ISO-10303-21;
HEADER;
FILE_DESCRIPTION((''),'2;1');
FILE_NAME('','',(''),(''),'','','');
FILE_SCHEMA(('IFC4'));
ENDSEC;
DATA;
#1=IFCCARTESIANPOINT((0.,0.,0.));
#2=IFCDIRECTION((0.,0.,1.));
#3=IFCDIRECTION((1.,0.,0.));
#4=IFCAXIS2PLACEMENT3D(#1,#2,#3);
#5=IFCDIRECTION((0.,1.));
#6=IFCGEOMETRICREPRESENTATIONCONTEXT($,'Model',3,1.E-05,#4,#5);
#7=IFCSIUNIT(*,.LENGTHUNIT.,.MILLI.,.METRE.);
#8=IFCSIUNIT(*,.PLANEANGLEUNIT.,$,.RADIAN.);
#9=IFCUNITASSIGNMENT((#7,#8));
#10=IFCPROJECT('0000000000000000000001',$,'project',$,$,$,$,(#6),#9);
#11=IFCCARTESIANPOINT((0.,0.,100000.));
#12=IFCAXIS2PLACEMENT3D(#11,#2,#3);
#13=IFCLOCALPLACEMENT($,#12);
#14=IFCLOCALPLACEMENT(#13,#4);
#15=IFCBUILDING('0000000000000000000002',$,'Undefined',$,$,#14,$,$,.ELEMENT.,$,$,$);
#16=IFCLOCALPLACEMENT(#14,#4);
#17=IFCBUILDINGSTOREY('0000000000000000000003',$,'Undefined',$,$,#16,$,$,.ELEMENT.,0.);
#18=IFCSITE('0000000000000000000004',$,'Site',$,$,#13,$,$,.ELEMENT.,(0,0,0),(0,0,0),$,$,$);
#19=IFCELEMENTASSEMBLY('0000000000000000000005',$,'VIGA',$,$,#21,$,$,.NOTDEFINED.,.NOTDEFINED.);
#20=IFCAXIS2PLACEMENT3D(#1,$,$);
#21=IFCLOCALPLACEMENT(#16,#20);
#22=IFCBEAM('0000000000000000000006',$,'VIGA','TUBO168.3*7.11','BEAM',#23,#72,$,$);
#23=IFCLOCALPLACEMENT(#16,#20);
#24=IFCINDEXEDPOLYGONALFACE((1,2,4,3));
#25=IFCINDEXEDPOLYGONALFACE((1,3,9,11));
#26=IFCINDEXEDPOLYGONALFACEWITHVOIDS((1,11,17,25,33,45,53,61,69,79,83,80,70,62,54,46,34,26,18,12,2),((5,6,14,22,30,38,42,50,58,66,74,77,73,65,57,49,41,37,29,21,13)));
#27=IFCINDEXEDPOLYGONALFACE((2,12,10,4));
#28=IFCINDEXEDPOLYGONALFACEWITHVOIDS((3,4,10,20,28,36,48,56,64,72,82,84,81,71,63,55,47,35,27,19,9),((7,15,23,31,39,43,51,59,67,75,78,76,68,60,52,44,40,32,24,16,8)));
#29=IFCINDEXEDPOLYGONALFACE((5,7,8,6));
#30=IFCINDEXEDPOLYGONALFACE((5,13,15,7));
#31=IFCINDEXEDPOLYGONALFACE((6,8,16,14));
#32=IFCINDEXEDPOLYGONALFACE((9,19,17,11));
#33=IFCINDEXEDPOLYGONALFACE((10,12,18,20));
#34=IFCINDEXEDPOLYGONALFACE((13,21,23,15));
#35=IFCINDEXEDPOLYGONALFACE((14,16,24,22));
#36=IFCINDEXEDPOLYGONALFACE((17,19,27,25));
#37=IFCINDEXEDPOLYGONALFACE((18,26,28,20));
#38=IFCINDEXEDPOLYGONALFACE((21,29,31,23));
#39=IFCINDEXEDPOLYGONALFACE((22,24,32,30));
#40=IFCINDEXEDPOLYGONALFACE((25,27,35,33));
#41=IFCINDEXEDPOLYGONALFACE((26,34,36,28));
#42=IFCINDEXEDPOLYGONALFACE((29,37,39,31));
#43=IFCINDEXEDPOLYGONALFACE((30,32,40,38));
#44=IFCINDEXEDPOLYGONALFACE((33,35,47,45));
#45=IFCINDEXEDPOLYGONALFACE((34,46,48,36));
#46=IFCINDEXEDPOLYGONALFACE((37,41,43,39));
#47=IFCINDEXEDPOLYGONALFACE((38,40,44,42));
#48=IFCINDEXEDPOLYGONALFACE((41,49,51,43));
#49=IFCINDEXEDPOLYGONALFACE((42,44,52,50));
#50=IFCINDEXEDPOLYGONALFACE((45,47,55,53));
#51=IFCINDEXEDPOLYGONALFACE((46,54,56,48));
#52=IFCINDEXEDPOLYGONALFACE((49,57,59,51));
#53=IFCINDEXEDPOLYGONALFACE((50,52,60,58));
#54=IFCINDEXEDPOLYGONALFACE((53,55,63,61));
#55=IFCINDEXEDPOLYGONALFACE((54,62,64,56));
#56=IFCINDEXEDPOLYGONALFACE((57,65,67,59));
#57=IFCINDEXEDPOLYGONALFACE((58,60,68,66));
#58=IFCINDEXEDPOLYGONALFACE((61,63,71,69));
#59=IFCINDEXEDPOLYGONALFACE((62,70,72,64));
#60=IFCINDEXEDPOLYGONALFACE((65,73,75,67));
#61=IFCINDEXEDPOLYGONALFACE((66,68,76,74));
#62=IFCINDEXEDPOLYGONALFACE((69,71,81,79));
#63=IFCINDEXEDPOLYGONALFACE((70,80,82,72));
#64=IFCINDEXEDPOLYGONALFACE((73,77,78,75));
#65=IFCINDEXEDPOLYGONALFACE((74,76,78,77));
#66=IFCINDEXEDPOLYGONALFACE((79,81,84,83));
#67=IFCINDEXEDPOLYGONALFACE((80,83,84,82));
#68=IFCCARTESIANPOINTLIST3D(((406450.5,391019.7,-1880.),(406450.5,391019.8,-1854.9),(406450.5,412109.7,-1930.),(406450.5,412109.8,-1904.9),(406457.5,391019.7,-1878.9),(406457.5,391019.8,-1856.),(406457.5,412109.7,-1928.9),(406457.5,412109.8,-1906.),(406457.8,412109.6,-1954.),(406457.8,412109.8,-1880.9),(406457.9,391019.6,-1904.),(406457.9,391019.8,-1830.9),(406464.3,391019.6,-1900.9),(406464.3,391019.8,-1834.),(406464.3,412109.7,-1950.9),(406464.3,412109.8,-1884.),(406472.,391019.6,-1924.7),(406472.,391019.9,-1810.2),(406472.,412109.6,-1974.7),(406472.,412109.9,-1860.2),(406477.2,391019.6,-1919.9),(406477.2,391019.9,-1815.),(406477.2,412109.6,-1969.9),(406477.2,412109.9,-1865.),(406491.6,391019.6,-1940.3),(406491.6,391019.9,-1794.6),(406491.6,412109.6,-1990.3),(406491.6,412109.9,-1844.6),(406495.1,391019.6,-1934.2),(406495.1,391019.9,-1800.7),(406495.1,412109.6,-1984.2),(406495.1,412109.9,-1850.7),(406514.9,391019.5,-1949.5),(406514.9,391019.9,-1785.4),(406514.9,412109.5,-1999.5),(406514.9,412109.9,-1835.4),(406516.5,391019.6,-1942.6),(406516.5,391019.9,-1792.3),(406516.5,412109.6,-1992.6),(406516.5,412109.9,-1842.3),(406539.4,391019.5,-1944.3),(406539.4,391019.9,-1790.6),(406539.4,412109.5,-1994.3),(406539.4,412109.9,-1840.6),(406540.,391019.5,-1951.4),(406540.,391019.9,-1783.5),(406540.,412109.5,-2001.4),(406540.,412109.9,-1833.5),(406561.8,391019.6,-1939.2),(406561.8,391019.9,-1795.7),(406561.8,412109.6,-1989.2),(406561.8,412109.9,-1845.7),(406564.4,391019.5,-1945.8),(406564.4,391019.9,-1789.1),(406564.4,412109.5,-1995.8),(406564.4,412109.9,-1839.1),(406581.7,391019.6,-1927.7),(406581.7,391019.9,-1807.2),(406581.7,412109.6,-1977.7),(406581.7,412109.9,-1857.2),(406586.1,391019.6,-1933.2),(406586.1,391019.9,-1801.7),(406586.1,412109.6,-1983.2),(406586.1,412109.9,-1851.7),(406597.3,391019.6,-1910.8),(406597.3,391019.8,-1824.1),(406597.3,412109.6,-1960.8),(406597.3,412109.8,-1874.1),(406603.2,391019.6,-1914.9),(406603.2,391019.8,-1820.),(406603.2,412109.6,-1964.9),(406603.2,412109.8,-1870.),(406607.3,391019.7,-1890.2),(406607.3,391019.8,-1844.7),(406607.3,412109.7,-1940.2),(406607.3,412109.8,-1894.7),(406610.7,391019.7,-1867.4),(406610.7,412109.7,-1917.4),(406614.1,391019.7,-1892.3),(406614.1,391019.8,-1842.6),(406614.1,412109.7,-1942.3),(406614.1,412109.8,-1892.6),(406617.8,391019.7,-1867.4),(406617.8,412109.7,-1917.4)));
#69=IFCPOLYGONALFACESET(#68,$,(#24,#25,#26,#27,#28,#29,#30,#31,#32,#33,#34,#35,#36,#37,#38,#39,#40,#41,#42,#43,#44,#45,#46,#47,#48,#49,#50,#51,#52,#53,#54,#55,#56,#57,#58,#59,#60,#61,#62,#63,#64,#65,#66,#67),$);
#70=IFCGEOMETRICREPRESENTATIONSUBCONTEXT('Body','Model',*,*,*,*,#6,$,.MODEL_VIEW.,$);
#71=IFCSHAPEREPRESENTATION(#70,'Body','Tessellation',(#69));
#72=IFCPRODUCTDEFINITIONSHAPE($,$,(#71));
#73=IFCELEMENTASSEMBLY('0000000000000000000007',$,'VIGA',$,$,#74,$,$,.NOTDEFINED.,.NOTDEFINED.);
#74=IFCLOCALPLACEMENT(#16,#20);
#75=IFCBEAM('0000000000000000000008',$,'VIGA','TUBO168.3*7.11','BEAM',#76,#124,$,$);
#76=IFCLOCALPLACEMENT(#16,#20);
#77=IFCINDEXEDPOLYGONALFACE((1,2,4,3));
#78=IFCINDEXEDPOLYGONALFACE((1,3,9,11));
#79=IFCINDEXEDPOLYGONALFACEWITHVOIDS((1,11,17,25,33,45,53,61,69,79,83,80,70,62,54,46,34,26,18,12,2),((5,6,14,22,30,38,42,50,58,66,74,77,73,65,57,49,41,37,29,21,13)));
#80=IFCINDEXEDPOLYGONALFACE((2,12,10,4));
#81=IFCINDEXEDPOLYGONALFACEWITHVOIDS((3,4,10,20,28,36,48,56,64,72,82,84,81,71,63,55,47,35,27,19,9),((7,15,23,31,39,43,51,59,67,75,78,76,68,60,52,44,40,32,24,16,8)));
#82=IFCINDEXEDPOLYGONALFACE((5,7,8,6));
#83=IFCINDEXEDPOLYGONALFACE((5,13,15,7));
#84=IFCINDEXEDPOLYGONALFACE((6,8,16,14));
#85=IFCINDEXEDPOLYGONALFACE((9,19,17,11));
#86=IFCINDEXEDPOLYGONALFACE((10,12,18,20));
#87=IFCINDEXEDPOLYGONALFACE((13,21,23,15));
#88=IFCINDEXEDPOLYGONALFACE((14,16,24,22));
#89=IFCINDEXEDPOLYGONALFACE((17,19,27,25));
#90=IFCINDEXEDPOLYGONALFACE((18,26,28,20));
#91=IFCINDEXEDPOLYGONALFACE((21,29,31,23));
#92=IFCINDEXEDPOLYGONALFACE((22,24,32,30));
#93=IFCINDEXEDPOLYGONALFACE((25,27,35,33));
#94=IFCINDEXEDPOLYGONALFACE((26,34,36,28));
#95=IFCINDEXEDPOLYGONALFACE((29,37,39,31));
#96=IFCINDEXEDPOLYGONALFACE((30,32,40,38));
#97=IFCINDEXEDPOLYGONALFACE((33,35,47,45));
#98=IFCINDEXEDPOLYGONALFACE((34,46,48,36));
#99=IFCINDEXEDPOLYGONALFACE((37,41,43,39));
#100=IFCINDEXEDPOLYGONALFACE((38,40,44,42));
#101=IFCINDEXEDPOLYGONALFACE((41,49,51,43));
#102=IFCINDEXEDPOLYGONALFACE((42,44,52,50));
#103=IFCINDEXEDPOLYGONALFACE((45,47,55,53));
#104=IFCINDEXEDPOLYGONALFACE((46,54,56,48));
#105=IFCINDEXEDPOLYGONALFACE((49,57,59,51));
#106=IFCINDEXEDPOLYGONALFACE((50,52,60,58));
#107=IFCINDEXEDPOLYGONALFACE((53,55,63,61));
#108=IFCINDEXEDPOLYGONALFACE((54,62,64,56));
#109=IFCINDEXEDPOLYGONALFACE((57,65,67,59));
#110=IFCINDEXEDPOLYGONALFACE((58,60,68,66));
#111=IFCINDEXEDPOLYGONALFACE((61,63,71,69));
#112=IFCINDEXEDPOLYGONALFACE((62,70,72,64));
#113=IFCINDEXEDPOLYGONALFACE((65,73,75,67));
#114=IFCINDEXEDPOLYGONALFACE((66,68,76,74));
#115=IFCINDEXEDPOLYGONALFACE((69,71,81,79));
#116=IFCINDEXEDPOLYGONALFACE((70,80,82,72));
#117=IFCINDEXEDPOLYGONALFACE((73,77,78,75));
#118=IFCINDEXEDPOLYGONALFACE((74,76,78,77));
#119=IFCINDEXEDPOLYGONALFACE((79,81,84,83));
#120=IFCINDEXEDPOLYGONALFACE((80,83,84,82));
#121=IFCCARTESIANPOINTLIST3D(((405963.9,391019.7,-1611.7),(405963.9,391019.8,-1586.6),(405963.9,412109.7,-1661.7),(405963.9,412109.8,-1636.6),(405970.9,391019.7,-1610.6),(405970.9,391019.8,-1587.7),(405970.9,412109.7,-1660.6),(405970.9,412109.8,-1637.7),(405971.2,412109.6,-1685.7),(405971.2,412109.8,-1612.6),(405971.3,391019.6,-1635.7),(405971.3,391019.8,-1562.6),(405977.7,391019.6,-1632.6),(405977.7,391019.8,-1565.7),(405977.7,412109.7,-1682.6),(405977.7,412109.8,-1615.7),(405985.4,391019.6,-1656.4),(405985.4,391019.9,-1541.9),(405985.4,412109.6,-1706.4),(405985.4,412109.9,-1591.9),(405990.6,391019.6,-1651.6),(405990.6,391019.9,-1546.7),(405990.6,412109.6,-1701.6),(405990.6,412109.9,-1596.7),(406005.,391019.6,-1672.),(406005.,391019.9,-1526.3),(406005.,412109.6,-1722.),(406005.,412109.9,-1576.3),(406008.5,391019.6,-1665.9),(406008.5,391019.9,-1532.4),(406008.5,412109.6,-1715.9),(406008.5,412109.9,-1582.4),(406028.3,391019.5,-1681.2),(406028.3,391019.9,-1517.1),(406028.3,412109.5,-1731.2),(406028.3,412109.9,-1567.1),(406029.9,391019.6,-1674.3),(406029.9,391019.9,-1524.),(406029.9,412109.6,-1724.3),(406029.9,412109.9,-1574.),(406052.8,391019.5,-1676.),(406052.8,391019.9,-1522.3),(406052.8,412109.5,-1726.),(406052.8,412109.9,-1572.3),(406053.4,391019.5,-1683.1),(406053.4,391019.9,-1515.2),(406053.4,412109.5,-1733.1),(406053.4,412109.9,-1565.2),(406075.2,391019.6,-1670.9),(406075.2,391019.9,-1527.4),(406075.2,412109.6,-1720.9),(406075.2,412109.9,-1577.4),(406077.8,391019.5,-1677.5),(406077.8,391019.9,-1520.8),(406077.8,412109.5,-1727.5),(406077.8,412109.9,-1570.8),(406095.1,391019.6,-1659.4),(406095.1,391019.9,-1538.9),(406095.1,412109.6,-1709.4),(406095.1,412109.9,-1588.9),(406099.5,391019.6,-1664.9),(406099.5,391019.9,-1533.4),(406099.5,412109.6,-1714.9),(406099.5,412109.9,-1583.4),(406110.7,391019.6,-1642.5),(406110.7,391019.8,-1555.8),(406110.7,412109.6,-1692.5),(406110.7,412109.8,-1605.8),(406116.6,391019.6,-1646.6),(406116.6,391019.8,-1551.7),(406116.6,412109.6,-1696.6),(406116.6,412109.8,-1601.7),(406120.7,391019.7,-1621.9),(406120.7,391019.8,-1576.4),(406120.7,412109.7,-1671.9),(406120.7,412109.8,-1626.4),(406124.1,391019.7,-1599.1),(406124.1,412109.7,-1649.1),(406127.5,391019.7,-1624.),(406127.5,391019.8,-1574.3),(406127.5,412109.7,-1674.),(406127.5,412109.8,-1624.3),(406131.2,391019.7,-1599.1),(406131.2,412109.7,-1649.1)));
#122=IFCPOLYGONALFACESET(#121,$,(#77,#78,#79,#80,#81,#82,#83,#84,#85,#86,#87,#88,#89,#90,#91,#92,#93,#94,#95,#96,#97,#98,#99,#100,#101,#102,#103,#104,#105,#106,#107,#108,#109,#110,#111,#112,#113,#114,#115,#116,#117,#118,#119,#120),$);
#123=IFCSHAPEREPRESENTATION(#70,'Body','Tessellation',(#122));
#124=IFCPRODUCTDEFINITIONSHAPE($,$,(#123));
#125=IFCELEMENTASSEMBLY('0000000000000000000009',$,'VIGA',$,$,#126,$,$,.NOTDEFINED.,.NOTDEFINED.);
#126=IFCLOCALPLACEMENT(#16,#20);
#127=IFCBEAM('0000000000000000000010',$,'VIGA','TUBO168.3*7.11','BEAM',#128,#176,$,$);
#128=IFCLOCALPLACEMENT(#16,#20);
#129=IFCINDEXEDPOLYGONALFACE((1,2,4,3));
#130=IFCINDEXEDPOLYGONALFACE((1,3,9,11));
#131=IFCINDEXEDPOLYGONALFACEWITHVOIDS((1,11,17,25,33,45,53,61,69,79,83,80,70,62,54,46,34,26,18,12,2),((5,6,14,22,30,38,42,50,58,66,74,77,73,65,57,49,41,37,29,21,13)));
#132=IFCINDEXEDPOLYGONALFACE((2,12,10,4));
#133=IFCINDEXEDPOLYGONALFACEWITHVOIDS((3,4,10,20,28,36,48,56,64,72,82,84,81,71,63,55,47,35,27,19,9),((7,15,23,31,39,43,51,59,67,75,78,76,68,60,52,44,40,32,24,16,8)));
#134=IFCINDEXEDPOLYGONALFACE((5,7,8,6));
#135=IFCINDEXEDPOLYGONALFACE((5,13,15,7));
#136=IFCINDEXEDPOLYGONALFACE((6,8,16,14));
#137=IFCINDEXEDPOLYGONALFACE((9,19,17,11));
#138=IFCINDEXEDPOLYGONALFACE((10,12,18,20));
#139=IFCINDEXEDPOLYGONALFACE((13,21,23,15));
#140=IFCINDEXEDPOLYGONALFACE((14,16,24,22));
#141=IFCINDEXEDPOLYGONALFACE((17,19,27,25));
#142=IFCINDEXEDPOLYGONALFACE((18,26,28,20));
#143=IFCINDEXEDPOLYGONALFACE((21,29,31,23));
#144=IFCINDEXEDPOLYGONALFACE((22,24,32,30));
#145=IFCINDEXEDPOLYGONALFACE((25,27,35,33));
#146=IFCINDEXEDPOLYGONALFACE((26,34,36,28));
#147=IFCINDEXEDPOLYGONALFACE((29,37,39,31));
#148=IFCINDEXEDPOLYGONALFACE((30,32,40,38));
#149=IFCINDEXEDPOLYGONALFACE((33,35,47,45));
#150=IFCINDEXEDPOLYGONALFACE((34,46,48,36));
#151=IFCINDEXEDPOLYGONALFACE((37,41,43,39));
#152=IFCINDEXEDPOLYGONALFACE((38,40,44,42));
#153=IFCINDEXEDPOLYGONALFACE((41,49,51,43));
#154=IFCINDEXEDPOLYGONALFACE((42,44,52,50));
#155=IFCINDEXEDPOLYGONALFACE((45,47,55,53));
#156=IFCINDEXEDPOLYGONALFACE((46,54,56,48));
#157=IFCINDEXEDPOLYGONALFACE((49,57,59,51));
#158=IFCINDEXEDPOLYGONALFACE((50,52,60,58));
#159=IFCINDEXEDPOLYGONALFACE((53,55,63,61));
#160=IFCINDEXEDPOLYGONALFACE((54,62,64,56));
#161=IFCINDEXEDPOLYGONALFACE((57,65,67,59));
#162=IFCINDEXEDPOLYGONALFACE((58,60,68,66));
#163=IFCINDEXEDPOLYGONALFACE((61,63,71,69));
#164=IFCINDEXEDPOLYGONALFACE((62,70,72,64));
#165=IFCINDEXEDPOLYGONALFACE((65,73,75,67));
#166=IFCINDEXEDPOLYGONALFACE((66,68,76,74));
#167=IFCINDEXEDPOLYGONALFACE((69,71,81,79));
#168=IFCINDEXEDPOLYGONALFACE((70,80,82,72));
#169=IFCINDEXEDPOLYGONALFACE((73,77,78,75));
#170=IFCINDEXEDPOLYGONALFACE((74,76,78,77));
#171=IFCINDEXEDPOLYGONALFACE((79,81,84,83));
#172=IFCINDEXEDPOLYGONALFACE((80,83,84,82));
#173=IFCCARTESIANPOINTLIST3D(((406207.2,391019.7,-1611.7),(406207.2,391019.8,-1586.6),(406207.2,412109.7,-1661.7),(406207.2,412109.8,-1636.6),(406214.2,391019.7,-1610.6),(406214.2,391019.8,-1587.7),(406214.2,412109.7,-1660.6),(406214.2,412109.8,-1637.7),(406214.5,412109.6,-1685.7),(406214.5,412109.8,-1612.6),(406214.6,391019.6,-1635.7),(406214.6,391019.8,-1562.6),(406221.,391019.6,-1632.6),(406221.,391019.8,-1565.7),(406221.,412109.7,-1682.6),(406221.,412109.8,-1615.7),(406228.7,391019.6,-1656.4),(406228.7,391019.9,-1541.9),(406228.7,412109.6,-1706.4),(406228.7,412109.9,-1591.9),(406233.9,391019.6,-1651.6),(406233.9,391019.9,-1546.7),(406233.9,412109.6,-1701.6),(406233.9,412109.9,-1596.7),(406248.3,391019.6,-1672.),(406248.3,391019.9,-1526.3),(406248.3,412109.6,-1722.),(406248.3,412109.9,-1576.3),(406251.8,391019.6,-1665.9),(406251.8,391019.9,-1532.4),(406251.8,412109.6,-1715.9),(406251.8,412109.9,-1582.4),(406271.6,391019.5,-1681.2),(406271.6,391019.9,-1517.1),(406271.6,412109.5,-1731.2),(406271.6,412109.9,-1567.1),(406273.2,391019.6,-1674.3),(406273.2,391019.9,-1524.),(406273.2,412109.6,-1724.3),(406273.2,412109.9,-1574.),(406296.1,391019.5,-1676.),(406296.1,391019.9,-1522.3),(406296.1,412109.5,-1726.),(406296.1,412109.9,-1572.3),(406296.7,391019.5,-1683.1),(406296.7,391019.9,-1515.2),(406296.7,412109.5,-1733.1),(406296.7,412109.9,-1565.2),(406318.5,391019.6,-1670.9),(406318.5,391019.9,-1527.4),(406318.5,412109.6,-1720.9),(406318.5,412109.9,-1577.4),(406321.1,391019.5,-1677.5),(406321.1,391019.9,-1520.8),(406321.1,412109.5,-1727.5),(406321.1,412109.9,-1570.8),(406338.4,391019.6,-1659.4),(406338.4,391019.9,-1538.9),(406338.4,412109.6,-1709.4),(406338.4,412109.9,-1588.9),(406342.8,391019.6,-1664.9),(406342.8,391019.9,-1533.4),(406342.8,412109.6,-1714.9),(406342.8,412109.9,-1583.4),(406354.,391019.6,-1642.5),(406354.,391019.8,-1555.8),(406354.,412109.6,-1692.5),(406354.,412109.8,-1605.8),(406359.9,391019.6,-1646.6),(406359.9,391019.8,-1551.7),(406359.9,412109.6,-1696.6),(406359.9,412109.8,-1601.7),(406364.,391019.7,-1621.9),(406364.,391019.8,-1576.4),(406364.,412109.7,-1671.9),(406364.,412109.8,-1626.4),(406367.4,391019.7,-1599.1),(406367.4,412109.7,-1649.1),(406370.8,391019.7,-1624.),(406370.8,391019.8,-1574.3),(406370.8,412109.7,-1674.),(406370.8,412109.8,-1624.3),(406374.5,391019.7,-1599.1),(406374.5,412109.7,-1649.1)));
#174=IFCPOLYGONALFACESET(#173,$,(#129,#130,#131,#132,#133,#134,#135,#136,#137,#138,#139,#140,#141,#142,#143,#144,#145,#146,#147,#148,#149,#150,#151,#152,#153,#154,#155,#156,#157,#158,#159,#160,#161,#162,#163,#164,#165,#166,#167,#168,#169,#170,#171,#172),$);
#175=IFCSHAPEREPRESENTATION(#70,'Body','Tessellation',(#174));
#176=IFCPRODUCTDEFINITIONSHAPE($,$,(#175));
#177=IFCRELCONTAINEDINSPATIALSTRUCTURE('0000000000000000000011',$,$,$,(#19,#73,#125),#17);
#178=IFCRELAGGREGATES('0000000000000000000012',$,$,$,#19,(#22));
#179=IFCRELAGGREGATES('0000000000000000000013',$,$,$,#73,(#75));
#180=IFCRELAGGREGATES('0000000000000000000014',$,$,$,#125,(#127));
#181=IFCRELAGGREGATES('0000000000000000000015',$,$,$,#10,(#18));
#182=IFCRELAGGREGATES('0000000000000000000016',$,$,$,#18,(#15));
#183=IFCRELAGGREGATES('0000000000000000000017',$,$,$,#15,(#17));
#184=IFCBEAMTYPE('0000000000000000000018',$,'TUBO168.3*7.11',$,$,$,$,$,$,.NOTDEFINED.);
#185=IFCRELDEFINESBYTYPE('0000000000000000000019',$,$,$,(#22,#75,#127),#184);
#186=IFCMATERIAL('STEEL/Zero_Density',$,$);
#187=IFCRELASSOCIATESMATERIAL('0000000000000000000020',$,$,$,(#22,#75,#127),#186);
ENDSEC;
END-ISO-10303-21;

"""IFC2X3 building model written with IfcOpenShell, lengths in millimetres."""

from ifc_helpers import new_model, si_unit, direction, frame, origin_with_axes, origin_2d_with_axis, place, context, subcontext, project, spatial, hollow_circle, extrude, material, type_object, element, aggregate, save


model = new_model("IFC2X3")

# Units and contexts
model_context = context("Model", 3, precision=1e-05, world=origin_with_axes(), true_north=direction((0.0, 1.0)))
body_context = subcontext(model_context, "Body", "Model", "MODEL_VIEW")
ifc_project = project(units=[si_unit("LENGTHUNIT", "METRE", prefix="MILLI"), si_unit("PLANEANGLEUNIT", "RADIAN")], contexts=[model_context])

# Site, building, storey
site_placement = place(None, frame((0.0, 0.0, 100000.0), z_axis=(0.0, 0.0, 1.0), x_axis=(1.0, 0.0, 0.0)))
site = spatial("IfcSite", under=ifc_project, at=site_placement, Name="Site", CompositionType="ELEMENT", RefLatitude=(0, 0, 0), RefLongitude=(0, 0, 0))
building_placement = place(site_placement, origin_with_axes())
building = spatial("IfcBuilding", under=site, at=building_placement, Name="Undefined", CompositionType="ELEMENT")
storey_placement = place(building_placement, origin_with_axes())
storey = spatial("IfcBuildingStorey", under=building, at=storey_placement, Name="Undefined", CompositionType="ELEMENT", Elevation=0.0)

# Element assemblies, beams
beam_type_1 = type_object("IfcBeamType", Name="TUBO168.3*7.11", PredefinedType="NOTDEFINED")
ifc_material_1 = material(Name="STEEL/Zero_Density")
assembly_1_placement = place(storey_placement, origin_with_axes())
assembly_1 = element("IfcElementAssembly", 1, at=assembly_1_placement, inside=storey, Name="VIGA", AssemblyPlace="NOTDEFINED", PredefinedType="NOTDEFINED")
beam_1_placement = place(assembly_1_placement, frame((406533.7, 391019.7, -1867.4), z_axis=(0.0, 0.002371, 0.999997), x_axis=(0.0, 0.999997, -0.002371)))
beam_1 = element("IfcBeam", 2, at=beam_1_placement, type_object=beam_type_1, material=ifc_material_1, Name="VIGA", Description="TUBO168.3*7.11", ObjectType="BEAM", context=body_context, shape_type="SweptSolid", body=[
    extrude(hollow_circle(Radius=84.2, WallThickness=7.1, at=origin_2d_with_axis()), frame((21090.1, 0.0, 0.0), z_axis=(-1.0, 0.0, 0.0), x_axis=(0.0, -1.0, 0.0)), (0.0, 0.0, 1.0), 21090.1),
])
aggregate(assembly_1, [beam_1])
assembly_2_placement = place(storey_placement, origin_with_axes())
assembly_2 = element("IfcElementAssembly", 3, at=assembly_2_placement, inside=storey, Name="VIGA", AssemblyPlace="NOTDEFINED", PredefinedType="NOTDEFINED")
beam_2_placement = place(assembly_2_placement, frame((406047.1, 391019.7, -1599.1), z_axis=(0.0, 0.002371, 0.999997), x_axis=(0.0, 0.999997, -0.002371)))
beam_2 = element("IfcBeam", 4, at=beam_2_placement, type_object=beam_type_1, material=ifc_material_1, Name="VIGA", Description="TUBO168.3*7.11", ObjectType="BEAM", context=body_context, shape_type="SweptSolid", body=[
    extrude(hollow_circle(Radius=84.2, WallThickness=7.1, at=origin_2d_with_axis()), frame((21090.1, 0.0, 0.0), z_axis=(-1.0, 0.0, 0.0), x_axis=(0.0, -1.0, 0.0)), (0.0, 0.0, 1.0), 21090.1),
])
aggregate(assembly_2, [beam_2])
assembly_3_placement = place(storey_placement, origin_with_axes())
assembly_3 = element("IfcElementAssembly", 5, at=assembly_3_placement, inside=storey, Name="VIGA", AssemblyPlace="NOTDEFINED", PredefinedType="NOTDEFINED")
beam_3_placement = place(assembly_3_placement, frame((406290.4, 391019.7, -1599.1), z_axis=(0.0, 0.002371, 0.999997), x_axis=(0.0, 0.999997, -0.002371)))
beam_3 = element("IfcBeam", 6, at=beam_3_placement, type_object=beam_type_1, material=ifc_material_1, Name="VIGA", Description="TUBO168.3*7.11", ObjectType="BEAM", context=body_context, shape_type="SweptSolid", body=[
    extrude(hollow_circle(Radius=84.2, WallThickness=7.1, at=origin_2d_with_axis()), frame((21090.1, 0.0, 0.0), z_axis=(-1.0, 0.0, 0.0), x_axis=(0.0, -1.0, 0.0)), (0.0, 0.0, 1.0), 21090.1),
])
aggregate(assembly_3, [beam_3])

save(model, "model.ifc")
